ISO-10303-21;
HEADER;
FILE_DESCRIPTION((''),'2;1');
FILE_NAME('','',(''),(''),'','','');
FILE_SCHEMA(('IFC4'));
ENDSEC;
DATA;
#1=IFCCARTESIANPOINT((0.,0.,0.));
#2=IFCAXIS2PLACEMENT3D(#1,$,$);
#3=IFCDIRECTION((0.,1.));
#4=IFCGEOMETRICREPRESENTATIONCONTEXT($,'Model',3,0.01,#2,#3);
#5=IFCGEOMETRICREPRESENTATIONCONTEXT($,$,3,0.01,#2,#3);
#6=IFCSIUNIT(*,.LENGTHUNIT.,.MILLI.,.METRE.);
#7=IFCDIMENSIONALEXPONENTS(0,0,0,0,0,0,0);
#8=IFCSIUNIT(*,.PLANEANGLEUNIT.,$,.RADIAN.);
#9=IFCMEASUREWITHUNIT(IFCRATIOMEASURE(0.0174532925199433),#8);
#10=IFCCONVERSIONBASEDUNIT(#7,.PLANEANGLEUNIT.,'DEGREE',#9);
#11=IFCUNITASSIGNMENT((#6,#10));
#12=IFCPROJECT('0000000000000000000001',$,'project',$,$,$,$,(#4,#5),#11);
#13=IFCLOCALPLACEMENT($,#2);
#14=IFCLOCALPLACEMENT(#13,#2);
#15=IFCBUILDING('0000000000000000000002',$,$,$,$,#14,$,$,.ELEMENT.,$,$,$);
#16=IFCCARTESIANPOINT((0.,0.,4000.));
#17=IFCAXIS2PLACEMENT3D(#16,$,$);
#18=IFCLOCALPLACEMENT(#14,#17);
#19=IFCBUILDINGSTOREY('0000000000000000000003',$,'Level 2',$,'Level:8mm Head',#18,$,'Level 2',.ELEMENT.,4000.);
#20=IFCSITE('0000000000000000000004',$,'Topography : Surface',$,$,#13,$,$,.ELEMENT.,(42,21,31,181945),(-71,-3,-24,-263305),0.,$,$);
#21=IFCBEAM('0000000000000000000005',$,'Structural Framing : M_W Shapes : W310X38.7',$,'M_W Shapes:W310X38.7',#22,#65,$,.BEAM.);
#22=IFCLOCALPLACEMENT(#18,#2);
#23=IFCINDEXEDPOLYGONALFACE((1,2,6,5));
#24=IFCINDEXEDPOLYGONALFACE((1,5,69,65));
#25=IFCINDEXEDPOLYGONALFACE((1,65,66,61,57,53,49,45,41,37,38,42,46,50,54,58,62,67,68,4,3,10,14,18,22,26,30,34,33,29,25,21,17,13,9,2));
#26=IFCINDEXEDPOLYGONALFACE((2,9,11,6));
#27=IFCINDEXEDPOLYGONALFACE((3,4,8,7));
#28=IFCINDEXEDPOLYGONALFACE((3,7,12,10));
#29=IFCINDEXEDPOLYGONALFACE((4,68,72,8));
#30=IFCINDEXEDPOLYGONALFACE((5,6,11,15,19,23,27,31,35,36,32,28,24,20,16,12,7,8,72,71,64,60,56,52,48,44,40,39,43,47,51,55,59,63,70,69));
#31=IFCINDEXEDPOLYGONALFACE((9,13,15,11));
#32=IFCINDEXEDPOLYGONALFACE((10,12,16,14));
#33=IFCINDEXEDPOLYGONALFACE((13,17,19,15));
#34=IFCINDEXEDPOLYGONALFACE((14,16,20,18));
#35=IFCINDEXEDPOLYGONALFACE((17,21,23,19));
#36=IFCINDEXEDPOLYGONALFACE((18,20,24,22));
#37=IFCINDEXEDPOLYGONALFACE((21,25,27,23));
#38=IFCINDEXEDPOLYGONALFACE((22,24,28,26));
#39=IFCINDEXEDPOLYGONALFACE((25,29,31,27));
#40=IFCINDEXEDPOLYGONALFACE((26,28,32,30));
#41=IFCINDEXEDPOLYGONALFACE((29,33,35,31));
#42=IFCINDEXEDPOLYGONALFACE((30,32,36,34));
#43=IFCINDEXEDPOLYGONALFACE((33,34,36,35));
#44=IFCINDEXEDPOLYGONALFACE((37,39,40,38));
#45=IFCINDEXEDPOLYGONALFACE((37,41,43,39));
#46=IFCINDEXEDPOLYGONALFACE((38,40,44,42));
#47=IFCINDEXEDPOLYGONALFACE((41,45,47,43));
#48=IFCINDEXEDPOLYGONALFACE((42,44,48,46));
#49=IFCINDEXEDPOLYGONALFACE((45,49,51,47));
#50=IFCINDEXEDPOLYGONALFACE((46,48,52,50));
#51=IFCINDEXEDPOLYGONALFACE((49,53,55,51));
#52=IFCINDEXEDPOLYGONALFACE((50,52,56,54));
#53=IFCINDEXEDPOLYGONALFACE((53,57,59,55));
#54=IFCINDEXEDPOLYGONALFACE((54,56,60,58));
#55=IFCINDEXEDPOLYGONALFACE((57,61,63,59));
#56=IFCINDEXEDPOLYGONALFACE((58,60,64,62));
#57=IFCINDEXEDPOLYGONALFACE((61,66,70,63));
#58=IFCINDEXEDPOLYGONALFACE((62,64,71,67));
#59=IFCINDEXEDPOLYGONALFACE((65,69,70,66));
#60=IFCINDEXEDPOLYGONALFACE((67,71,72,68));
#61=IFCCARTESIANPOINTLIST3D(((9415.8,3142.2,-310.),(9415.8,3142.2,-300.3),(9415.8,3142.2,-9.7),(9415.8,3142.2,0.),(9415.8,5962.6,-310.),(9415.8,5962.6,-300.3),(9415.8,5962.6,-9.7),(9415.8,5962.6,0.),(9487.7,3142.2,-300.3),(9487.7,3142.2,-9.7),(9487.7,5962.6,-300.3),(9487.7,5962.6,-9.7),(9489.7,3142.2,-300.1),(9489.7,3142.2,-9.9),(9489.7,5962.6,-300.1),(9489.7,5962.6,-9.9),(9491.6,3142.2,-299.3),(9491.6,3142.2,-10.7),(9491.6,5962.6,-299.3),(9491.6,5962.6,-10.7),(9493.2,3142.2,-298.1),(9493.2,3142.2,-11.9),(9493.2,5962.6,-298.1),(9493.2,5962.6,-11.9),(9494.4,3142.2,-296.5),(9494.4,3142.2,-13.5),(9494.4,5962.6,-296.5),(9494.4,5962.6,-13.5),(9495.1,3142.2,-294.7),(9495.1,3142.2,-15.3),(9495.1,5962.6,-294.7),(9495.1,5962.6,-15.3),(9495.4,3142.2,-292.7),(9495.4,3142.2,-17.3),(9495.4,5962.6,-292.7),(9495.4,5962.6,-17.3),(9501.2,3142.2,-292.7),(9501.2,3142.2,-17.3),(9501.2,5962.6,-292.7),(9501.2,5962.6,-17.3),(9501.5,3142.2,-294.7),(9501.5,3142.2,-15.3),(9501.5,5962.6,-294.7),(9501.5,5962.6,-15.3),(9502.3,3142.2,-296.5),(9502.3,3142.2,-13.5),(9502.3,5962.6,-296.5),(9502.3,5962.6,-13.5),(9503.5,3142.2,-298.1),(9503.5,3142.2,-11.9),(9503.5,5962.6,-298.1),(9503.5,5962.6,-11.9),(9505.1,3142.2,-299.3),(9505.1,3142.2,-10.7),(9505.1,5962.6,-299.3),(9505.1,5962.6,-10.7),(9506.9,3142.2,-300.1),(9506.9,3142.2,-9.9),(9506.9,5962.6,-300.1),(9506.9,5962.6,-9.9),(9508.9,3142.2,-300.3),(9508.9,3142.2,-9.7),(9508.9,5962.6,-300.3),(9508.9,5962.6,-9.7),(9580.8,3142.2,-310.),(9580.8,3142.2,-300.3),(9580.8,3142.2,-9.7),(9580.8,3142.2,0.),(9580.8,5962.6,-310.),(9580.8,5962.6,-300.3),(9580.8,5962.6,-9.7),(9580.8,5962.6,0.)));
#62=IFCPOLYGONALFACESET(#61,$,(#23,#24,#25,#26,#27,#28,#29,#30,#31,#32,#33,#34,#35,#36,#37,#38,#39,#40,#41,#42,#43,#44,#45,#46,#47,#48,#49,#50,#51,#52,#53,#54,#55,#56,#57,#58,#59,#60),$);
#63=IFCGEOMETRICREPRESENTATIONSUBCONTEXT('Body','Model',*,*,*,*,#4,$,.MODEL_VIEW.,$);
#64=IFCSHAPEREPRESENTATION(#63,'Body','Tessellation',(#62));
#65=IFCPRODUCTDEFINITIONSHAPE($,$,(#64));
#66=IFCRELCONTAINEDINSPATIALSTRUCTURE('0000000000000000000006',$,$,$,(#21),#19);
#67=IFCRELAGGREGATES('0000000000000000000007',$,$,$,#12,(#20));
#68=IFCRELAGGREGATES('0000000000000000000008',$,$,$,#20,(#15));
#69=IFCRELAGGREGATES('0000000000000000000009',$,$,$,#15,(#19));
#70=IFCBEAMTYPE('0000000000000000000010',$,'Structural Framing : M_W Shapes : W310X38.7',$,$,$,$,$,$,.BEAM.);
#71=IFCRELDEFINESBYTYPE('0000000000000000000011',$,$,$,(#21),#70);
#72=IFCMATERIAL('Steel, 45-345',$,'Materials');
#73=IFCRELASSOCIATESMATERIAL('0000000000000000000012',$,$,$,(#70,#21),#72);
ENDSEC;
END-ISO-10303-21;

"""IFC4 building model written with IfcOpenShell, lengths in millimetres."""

from ifc_helpers import new_model, entity, si_unit, converted_unit, direction, frame, frame_2d, origin, place, context, subcontext, project, spatial, i_section, extrude, source, transform, mapped, material, material_profile, profile_set, profile_usage, type_object, type_shapes, element, save


model = new_model("IFC4")

# Units and contexts
model_context = context("Model", 3, precision=0.01, world=origin(), true_north=direction((0.0, 1.0)))
context_of_model = context(None, 3, precision=0.01, world=origin(), true_north=direction((0.0, 1.0)))
body_context = subcontext(model_context, "Body", "Model", "MODEL_VIEW")
ifc_project = project(units=[si_unit("LENGTHUNIT", "METRE", prefix="MILLI"), converted_unit("PLANEANGLEUNIT", "DEGREE", entity("IfcRatioMeasure", 0.0174532925199433), si_unit("PLANEANGLEUNIT", "RADIAN"), dimensions=[0, 0, 0, 0, 0, 0, 0])], contexts=[model_context, context_of_model])

# Site, building, storey
site_placement = place(None, origin())
site = spatial("IfcSite", under=ifc_project, at=site_placement, Name="Topography : Surface", CompositionType="ELEMENT", RefLatitude=(42, 21, 31, 181945), RefLongitude=(-71, -3, -24, -263305), RefElevation=0.0)
building_placement = place(site_placement, origin())
building = spatial("IfcBuilding", under=site, at=building_placement, CompositionType="ELEMENT")
storey_placement = place(building_placement, frame((0.0, 0.0, 4000.0)))
storey = spatial("IfcBuildingStorey", under=building, at=storey_placement, Name="Level 2", ObjectType="Level:8mm Head", LongName="Level 2", CompositionType="ELEMENT", Elevation=4000.0)

# Beam
ifc_material = material(Name="Steel, 45-345", Category="Materials")
ifc_material_profile = material_profile(ifc_material, i_section(OverallWidth=165.0, OverallDepth=310.0, WebThickness=5.8, FlangeThickness=9.7, FilletRadius=7.7, at=frame_2d((0.0, 0.0), x_axis=(0.0, 1.0))), Name="W310X38.7")
ifc_profile_set = profile_set([ifc_material_profile], Name="W310X38.7")
ifc_profile_usage = profile_usage(ifc_profile_set, cardinal=8)
beam_type_1 = type_object("IfcBeamType", Name="Structural Framing : M_W Shapes : W310X38.7", PredefinedType="BEAM", material=ifc_profile_set)
shared_shape = source(origin(), body_context, "Body", "SweptSolid", [
    extrude(i_section(OverallWidth=165.0, OverallDepth=310.0, WebThickness=5.8, FlangeThickness=9.7, FilletRadius=7.7, at=frame_2d((0.0, 0.0), x_axis=(0.0, 1.0))), frame((-1410.2, 0.0, 0.0), z_axis=(1.0, 0.0, 0.0), x_axis=(0.0, 0.0, -1.0)), (0.0, 0.0, 1.0), 2820.4),
])
type_shapes(beam_type_1, [shared_shape])
beam_1_placement = place(storey_placement, frame((9498.3, 4552.4, -155.0), z_axis=(0.0, 0.0, 1.0), x_axis=(0.0, -1.0, 0.0)))
element("IfcBeam", 1, at=beam_1_placement, inside=storey, type_object=beam_type_1, material=ifc_profile_usage, Name="Structural Framing : M_W Shapes : W310X38.7", ObjectType="M_W Shapes:W310X38.7", PredefinedType="BEAM", context=body_context, shape_type="MappedRepresentation", body=[
    mapped(shared_shape, transform((0.0, 0.0, 0.0), scale=1.0)),
])

save(model, "model.ifc")
